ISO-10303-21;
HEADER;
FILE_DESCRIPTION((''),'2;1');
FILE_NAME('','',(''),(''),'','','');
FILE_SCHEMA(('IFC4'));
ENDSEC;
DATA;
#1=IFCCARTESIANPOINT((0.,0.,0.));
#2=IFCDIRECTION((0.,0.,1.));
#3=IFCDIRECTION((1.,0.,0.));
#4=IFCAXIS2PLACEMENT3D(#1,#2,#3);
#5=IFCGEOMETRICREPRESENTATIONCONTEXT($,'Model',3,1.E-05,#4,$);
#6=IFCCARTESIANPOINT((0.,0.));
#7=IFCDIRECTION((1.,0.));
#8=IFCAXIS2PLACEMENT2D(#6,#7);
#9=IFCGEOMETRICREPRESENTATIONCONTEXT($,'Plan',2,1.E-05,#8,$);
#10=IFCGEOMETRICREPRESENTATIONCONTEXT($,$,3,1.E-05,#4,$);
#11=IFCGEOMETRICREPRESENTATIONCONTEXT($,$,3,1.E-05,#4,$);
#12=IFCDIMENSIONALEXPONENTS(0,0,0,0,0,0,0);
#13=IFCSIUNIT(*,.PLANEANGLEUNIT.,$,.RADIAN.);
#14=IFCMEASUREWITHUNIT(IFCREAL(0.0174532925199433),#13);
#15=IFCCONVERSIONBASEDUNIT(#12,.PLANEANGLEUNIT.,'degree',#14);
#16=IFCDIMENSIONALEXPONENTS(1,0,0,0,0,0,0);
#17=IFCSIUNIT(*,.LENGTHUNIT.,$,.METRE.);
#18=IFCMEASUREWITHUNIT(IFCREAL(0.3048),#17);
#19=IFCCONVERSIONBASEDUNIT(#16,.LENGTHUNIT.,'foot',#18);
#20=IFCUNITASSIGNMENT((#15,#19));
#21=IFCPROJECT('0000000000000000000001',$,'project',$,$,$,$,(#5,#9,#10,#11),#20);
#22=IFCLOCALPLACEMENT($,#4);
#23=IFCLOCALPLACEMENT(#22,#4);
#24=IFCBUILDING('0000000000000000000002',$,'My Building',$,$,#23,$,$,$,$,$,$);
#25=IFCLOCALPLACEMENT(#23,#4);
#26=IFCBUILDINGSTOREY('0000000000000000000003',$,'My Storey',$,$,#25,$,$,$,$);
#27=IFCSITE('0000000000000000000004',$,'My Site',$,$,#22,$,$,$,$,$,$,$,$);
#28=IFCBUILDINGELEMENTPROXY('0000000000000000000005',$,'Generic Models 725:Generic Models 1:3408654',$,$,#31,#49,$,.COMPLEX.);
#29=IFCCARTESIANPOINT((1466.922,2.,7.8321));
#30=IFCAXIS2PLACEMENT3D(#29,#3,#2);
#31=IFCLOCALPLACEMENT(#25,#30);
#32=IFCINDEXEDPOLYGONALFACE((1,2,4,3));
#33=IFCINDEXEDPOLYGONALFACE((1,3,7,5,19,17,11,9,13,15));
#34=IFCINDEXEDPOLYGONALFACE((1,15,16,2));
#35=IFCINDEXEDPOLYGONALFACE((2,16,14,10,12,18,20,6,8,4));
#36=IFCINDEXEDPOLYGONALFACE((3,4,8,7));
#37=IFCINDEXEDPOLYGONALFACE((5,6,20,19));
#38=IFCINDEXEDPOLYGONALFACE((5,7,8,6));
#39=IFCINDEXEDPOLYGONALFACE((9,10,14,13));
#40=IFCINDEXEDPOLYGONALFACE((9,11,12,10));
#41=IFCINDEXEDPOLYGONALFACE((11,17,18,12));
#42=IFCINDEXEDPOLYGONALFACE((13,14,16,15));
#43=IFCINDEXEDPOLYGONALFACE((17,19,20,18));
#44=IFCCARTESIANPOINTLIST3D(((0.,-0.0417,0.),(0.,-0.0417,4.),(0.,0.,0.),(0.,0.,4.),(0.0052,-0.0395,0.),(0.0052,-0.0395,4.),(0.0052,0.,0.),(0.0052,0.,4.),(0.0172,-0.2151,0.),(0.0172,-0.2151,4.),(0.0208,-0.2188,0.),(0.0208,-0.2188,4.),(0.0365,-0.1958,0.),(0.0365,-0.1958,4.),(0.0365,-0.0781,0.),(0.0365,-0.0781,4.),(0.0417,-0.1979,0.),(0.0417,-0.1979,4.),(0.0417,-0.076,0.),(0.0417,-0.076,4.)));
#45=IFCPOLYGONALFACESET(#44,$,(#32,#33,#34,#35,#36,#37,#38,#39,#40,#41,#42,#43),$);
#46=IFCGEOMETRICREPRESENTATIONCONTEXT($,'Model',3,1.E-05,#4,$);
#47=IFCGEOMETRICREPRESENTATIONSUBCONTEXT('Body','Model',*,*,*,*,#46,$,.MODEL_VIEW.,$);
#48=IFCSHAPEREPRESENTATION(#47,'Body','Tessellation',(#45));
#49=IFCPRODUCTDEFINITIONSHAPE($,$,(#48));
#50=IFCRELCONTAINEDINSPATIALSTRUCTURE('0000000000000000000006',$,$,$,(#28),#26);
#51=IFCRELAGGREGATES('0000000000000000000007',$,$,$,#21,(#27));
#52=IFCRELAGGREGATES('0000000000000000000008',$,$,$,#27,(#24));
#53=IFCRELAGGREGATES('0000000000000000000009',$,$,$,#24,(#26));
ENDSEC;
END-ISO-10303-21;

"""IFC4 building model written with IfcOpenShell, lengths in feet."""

from ifc_helpers import new_model, entity, si_unit, converted_unit, frame, origin_with_axes, origin_2d_with_axis, place, context, subcontext, project, spatial, line, indexed_curve, outline, extrude, element, save


model = new_model("IFC4")

# Units and contexts
model_context_1 = context("Model", 3, precision=1e-05, world=origin_with_axes())
plan_context = context("Plan", 2, precision=1e-05, world=origin_2d_with_axis())
model_context_2 = context("Model", 3, precision=1e-05, world=origin_with_axes())
context_of_model_1 = context(None, 3, precision=1e-05, world=origin_with_axes())
context_of_model_2 = context(None, 3, precision=1e-05, world=origin_with_axes())
body_context_1 = subcontext(model_context_2, "Body", "Model", "MODEL_VIEW")
ifc_project = project(units=[converted_unit("PLANEANGLEUNIT", "degree", entity("IfcReal", 0.0174532925199433), si_unit("PLANEANGLEUNIT", "RADIAN"), dimensions=[0, 0, 0, 0, 0, 0, 0]), converted_unit("LENGTHUNIT", "foot", entity("IfcReal", 0.3048), si_unit("LENGTHUNIT", "METRE"), dimensions=[1, 0, 0, 0, 0, 0, 0])], contexts=[model_context_1, plan_context, context_of_model_1, context_of_model_2])

# Site, building, storey
site_placement = place(None, origin_with_axes())
site = spatial("IfcSite", under=ifc_project, at=site_placement, Name="My Site")
building_placement = place(site_placement, origin_with_axes())
building = spatial("IfcBuilding", under=site, at=building_placement, Name="My Building")
storey_placement = place(building_placement, origin_with_axes())
storey = spatial("IfcBuildingStorey", under=building, at=storey_placement, Name="My Storey")

# Building element proxy
proxy_1_placement = place(storey_placement, frame((1466.922, 2.0, 7.8321), z_axis=(1.0, 0.0, 0.0), x_axis=(0.0, 0.0, 1.0)))
element("IfcBuildingElementProxy", 1, at=proxy_1_placement, inside=storey, Name="Generic Models 725:Generic Models 1:3408654", PredefinedType="COMPLEX", context=body_context_1, shape_type="SweptSolid", body=[
    extrude(outline(indexed_curve([(0.0684, -0.0024), (0.1072, 0.0051), (0.1082, 0.0), (0.0673, -0.0079), (0.0246, 0.021), (-0.0909, -0.0012), (-0.1062, -0.0238), (-0.1105, -0.0209), (-0.094, 0.0035), (0.0258, 0.0266)], segments=[line(6, 5), line(5, 4), line(4, 3), line(3, 2), line(2, 1), line(1, 10), line(10, 9), line(9, 8), line(8, 7), line(7, 6)], self_intersect=False)), frame((0.0205, -0.1063, 0.0), z_axis=(0.0, 0.0, -1.0), x_axis=(-0.189091, 0.98196, 0.0)), (0.0, 0.0, -1.0), 4.0),
])

save(model, "model.ifc")
